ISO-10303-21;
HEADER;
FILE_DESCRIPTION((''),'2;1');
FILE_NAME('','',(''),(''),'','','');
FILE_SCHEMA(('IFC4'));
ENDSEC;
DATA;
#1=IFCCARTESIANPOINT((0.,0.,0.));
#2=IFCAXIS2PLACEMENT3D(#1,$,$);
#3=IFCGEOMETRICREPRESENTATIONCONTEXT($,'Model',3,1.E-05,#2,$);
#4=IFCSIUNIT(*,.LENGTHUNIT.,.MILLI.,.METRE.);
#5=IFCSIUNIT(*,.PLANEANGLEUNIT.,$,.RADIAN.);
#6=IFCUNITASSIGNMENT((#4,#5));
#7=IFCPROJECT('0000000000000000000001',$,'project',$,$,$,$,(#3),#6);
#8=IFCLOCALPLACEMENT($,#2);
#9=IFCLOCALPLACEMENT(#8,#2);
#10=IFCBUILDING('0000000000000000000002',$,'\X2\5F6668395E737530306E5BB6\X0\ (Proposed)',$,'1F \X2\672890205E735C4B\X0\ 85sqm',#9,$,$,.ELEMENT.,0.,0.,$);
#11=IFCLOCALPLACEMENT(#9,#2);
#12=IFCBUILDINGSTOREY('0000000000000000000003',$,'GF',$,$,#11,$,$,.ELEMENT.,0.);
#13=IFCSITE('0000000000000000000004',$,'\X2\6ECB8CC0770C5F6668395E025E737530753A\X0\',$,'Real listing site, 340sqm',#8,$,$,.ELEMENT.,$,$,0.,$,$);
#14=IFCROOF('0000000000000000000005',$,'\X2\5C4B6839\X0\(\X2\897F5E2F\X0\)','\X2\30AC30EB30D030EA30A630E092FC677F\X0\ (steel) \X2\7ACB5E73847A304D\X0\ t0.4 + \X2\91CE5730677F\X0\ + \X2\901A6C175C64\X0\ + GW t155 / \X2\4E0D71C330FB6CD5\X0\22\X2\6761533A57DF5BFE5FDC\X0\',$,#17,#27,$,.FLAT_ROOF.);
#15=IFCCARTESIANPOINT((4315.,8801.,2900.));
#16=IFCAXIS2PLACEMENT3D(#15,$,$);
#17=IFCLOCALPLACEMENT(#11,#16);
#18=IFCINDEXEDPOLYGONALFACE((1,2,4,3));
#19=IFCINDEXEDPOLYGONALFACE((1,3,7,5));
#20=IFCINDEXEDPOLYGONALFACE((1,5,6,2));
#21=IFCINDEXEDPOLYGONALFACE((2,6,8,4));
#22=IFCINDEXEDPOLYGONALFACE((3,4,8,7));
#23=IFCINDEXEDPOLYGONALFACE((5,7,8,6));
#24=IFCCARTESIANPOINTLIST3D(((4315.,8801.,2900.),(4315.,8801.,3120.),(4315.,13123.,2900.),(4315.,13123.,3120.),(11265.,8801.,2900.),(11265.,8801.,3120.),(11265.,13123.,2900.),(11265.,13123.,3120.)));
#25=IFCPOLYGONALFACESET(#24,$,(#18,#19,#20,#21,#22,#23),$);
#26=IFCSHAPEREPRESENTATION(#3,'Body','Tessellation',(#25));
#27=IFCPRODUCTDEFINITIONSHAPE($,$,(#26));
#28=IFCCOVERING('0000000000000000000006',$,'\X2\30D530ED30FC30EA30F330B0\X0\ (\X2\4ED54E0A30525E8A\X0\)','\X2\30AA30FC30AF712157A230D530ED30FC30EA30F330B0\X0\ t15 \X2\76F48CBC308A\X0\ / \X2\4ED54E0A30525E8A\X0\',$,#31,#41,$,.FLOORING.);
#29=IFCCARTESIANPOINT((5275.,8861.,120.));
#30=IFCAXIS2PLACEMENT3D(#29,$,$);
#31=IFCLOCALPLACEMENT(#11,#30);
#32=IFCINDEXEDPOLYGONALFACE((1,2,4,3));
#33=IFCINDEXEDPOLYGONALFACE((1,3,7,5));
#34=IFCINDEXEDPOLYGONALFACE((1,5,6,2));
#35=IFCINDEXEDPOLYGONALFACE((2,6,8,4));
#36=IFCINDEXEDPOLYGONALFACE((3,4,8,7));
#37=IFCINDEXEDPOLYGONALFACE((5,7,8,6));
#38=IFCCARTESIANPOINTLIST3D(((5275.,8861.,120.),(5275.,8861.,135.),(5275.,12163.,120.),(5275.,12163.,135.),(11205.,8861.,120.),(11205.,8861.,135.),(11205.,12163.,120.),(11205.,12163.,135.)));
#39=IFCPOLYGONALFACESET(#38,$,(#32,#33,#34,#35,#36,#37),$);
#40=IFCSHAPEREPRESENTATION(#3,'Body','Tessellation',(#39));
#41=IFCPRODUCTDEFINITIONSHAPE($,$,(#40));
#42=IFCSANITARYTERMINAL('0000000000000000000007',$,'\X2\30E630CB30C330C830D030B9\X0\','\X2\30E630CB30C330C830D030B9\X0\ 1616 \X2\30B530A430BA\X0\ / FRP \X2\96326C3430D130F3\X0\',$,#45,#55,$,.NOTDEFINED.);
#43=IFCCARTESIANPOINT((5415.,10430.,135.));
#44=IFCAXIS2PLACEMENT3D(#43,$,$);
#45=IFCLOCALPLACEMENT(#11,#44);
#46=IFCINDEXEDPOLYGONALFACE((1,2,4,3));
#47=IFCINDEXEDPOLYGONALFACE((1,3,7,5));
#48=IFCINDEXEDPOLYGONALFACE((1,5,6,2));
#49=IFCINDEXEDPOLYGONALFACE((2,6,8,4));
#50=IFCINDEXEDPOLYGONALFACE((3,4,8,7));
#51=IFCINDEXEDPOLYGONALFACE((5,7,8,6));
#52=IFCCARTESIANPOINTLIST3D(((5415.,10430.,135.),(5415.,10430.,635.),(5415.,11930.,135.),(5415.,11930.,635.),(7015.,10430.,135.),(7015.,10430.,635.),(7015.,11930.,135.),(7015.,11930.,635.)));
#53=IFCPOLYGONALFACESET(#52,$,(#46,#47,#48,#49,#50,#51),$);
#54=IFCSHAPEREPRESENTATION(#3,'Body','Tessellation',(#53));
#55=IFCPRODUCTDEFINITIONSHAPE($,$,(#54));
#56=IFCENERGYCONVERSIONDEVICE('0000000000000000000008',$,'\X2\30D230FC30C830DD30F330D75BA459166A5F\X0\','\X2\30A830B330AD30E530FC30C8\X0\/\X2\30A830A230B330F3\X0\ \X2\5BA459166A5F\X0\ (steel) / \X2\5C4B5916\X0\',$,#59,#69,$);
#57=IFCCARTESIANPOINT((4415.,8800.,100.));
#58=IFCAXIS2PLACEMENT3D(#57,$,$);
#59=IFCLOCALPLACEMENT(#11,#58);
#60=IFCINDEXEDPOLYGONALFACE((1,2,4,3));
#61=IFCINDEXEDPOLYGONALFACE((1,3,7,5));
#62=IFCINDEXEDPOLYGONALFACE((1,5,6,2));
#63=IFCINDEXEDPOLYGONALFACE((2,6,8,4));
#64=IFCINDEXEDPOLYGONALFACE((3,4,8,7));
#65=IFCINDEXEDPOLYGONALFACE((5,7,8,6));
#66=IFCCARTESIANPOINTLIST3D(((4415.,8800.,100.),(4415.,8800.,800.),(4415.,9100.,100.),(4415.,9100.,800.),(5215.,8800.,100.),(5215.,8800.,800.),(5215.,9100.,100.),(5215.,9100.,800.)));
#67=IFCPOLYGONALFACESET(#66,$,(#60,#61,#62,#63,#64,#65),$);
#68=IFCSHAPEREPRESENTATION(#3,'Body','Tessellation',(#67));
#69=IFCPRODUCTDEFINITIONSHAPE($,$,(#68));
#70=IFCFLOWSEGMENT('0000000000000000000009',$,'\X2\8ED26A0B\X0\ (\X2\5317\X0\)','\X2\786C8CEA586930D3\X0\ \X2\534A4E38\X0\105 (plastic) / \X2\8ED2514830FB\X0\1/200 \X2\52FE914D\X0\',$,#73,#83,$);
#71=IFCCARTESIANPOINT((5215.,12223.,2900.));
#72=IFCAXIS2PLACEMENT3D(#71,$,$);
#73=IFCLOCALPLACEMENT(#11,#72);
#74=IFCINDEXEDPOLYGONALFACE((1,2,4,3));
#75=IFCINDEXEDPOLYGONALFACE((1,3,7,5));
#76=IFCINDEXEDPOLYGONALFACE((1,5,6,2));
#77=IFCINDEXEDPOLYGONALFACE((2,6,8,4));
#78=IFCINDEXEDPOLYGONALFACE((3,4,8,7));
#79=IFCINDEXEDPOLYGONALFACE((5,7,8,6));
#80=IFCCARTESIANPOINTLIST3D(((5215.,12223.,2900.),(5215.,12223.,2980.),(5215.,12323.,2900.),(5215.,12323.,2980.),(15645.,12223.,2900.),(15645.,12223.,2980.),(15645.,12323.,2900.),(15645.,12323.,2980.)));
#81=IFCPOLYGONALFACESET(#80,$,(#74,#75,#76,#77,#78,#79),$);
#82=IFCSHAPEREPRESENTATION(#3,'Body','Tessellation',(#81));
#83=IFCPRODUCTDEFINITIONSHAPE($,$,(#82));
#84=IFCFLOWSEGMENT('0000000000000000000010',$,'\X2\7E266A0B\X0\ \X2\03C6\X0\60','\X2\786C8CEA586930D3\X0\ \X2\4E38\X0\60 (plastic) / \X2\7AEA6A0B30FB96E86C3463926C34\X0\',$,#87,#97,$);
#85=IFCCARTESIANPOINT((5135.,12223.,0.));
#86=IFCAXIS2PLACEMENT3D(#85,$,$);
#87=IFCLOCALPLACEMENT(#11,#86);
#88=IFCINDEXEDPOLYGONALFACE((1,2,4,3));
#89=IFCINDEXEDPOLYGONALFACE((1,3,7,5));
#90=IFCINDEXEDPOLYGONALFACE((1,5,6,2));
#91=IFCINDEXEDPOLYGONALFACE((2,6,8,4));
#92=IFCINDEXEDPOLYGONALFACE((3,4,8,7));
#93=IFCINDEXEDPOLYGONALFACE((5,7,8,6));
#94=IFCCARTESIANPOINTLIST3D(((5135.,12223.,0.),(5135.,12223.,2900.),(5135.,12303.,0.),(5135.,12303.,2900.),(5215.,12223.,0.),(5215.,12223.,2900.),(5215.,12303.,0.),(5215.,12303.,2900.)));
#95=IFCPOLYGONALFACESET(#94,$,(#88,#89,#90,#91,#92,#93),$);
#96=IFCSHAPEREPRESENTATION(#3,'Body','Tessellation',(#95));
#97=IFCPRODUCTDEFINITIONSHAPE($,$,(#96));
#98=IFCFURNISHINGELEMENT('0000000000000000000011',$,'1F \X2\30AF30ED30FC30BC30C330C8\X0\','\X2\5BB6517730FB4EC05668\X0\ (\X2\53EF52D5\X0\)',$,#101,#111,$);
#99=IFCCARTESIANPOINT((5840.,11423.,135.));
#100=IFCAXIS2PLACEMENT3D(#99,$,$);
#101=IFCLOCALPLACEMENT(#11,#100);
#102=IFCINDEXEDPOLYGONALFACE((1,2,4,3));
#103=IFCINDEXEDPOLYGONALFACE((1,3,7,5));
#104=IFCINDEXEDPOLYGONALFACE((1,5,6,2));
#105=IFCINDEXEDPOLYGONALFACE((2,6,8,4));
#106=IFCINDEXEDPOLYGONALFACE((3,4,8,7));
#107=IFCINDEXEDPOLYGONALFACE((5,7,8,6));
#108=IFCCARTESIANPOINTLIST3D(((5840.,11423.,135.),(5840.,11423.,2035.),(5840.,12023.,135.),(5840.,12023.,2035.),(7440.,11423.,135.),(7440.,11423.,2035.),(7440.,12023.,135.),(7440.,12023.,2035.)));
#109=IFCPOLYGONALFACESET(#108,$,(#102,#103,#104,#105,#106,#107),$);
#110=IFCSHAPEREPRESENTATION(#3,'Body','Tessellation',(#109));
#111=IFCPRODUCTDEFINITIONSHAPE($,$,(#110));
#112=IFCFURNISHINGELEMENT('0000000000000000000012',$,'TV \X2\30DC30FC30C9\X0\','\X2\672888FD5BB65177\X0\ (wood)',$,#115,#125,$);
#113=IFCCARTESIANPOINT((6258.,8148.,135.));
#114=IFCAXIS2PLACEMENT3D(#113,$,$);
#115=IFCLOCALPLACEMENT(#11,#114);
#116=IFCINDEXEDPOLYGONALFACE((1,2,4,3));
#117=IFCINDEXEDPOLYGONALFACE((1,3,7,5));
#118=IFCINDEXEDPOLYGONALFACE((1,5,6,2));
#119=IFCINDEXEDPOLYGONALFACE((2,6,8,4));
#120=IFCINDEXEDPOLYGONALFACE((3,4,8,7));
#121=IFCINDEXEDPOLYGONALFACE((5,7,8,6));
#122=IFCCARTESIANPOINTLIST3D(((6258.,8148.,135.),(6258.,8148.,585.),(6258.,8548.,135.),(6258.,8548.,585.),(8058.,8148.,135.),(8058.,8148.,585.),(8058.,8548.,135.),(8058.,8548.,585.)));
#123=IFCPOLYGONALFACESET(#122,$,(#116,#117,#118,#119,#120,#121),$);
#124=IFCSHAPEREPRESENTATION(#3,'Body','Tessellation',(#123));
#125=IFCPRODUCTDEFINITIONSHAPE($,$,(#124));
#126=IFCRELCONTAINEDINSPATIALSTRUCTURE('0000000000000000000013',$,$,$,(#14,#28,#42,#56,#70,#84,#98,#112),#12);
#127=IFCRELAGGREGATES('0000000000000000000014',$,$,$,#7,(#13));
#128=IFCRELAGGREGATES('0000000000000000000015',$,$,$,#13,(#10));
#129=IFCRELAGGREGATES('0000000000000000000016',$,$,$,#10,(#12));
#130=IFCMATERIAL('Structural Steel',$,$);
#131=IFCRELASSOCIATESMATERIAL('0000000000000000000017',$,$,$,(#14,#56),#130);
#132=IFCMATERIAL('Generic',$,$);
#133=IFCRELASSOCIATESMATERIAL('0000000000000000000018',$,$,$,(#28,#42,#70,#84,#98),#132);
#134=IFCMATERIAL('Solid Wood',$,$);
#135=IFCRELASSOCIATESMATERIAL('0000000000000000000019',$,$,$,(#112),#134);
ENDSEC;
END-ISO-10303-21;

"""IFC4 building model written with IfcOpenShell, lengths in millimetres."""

from ifc_helpers import new_model, si_unit, frame, frame_2d, origin, place, context, project, spatial, rectangle, extrude, material, element, save


model = new_model("IFC4")

# Units and contexts
model_context = context("Model", 3, precision=1e-05, world=origin())
ifc_project = project(units=[si_unit("LENGTHUNIT", "METRE", prefix="MILLI"), si_unit("PLANEANGLEUNIT", "RADIAN")], contexts=[model_context])

# Site, building, storey
site_placement = place(None, origin())
site = spatial("IfcSite", under=ifc_project, at=site_placement, Name="滋賀県彦根市平田町", ObjectType="Real listing site, 340sqm", CompositionType="ELEMENT", RefElevation=0.0)
building_placement = place(site_placement, origin())
building = spatial("IfcBuilding", under=site, at=building_placement, Name="彦根平田の家 (Proposed)", ObjectType="1F 木造平屋 85sqm", CompositionType="ELEMENT", ElevationOfRefHeight=0.0, ElevationOfTerrain=0.0)
storey_placement = place(building_placement, origin())
storey = spatial("IfcBuildingStorey", under=building, at=storey_placement, Name="GF", CompositionType="ELEMENT", Elevation=0.0)

# Shared definitions
ifc_material_1 = material(Name="Solid Wood")

# Roof
ifc_material_2 = material(Name="Structural Steel")
roof_placement = place(storey_placement, frame((4315.0, 8801.0, 2900.0)))
element("IfcRoof", 1, at=roof_placement, inside=storey, material=ifc_material_2, Name="屋根(西帯)", Description="ガルバリウム鋼板 (steel) 立平葺き t0.4 + 野地板 + 通気層 + GW t155 / 不燃・法22条区域対応", PredefinedType="FLAT_ROOF", context=model_context, shape_type="SweptSolid", body=[
    extrude(rectangle(XDim=6950.0, YDim=4322.0, at=frame_2d((3475.0, 2161.0))), frame((4315.0, 8801.0, 2900.0)), (0.0, 0.0, 1.0), 220.0),
])

# Covering
ifc_material_3 = material(Name="Generic")
covering_placement = place(storey_placement, frame((5275.0, 8861.0, 120.0)))
element("IfcCovering", 2, at=covering_placement, inside=storey, material=ifc_material_3, Name="フローリング (仕上げ床)", Description="オーク無垢フローリング t15 直貼り / 仕上げ床", PredefinedType="FLOORING", context=model_context, shape_type="SweptSolid", body=[
    extrude(rectangle(XDim=5930.0, YDim=3302.0, at=frame_2d((2965.0, 1651.0))), frame((5275.0, 8861.0, 120.0)), (0.0, 0.0, 1.0), 15.0),
])

# Sanitary terminal
sanitary_terminal_placement = place(storey_placement, frame((5415.0, 10430.0, 135.0)))
element("IfcSanitaryTerminal", 3, at=sanitary_terminal_placement, inside=storey, material=ifc_material_3, Name="ユニットバス", Description="ユニットバス 1616 サイズ / FRP 防水パン", PredefinedType="NOTDEFINED", context=model_context, shape_type="SweptSolid", body=[
    extrude(rectangle(XDim=1600.0, YDim=1500.0, at=frame_2d((800.0, 750.0))), frame((5415.0, 10430.0, 135.0)), (0.0, 0.0, 1.0), 500.0),
])

# Energy conversion device
energy_conversion_device_placement = place(storey_placement, frame((4415.0, 8800.0, 100.0)))
element("IfcEnergyConversionDevice", 4, at=energy_conversion_device_placement, inside=storey, material=ifc_material_2, Name="ヒートポンプ室外機", Description="エコキュート/エアコン 室外機 (steel) / 屋外", context=model_context, shape_type="SweptSolid", body=[
    extrude(rectangle(XDim=800.0, YDim=300.0, at=frame_2d((400.0, 150.0))), frame((4415.0, 8800.0, 100.0)), (0.0, 0.0, 1.0), 700.0),
])

# Flow segments
flow_segment_1_placement = place(storey_placement, frame((5215.0, 12223.0, 2900.0)))
element("IfcFlowSegment", 5, at=flow_segment_1_placement, inside=storey, material=ifc_material_3, Name="軒樋 (北)", Description="硬質塩ビ 半丸105 (plastic) / 軒先・1/200 勾配", context=model_context, shape_type="SweptSolid", body=[
    extrude(rectangle(XDim=10430.0, YDim=100.0, at=frame_2d((5215.0, 50.0))), frame((5215.0, 12223.0, 2900.0)), (0.0, 0.0, 1.0), 80.0),
])
flow_segment_2_placement = place(storey_placement, frame((5135.0, 12223.0, 0.0)))
element("IfcFlowSegment", 6, at=flow_segment_2_placement, inside=storey, material=ifc_material_3, Name="縦樋 φ60", Description="硬質塩ビ 丸60 (plastic) / 竪樋・雨水排水", context=model_context, shape_type="SweptSolid", body=[
    extrude(rectangle(XDim=80.0, YDim=80.0, at=frame_2d((40.0, 40.0))), frame((5135.0, 12223.0, 0.0)), (0.0, 0.0, 1.0), 2900.0),
])

# Furnishing elements
furnishing_1_placement = place(storey_placement, frame((5840.0, 11423.0, 135.0)))
element("IfcFurnishingElement", 7, at=furnishing_1_placement, inside=storey, material=ifc_material_3, Name="1F クローゼット", Description="家具・什器 (可動)", context=model_context, shape_type="SweptSolid", body=[
    extrude(rectangle(XDim=1600.0, YDim=600.0, at=frame_2d((800.0, 300.0))), frame((5840.0, 11423.0, 135.0)), (0.0, 0.0, 1.0), 1900.0),
])
furnishing_2_placement = place(storey_placement, frame((6258.0, 8148.0, 135.0)))
element("IfcFurnishingElement", 8, at=furnishing_2_placement, inside=storey, material=ifc_material_1, Name="TV ボード", Description="木製家具 (wood)", context=model_context, shape_type="SweptSolid", body=[
    extrude(rectangle(XDim=1800.0, YDim=400.0, at=frame_2d((900.0, 200.0))), frame((6258.0, 8148.0, 135.0)), (0.0, 0.0, 1.0), 450.0),
])

save(model, "model.ifc")
